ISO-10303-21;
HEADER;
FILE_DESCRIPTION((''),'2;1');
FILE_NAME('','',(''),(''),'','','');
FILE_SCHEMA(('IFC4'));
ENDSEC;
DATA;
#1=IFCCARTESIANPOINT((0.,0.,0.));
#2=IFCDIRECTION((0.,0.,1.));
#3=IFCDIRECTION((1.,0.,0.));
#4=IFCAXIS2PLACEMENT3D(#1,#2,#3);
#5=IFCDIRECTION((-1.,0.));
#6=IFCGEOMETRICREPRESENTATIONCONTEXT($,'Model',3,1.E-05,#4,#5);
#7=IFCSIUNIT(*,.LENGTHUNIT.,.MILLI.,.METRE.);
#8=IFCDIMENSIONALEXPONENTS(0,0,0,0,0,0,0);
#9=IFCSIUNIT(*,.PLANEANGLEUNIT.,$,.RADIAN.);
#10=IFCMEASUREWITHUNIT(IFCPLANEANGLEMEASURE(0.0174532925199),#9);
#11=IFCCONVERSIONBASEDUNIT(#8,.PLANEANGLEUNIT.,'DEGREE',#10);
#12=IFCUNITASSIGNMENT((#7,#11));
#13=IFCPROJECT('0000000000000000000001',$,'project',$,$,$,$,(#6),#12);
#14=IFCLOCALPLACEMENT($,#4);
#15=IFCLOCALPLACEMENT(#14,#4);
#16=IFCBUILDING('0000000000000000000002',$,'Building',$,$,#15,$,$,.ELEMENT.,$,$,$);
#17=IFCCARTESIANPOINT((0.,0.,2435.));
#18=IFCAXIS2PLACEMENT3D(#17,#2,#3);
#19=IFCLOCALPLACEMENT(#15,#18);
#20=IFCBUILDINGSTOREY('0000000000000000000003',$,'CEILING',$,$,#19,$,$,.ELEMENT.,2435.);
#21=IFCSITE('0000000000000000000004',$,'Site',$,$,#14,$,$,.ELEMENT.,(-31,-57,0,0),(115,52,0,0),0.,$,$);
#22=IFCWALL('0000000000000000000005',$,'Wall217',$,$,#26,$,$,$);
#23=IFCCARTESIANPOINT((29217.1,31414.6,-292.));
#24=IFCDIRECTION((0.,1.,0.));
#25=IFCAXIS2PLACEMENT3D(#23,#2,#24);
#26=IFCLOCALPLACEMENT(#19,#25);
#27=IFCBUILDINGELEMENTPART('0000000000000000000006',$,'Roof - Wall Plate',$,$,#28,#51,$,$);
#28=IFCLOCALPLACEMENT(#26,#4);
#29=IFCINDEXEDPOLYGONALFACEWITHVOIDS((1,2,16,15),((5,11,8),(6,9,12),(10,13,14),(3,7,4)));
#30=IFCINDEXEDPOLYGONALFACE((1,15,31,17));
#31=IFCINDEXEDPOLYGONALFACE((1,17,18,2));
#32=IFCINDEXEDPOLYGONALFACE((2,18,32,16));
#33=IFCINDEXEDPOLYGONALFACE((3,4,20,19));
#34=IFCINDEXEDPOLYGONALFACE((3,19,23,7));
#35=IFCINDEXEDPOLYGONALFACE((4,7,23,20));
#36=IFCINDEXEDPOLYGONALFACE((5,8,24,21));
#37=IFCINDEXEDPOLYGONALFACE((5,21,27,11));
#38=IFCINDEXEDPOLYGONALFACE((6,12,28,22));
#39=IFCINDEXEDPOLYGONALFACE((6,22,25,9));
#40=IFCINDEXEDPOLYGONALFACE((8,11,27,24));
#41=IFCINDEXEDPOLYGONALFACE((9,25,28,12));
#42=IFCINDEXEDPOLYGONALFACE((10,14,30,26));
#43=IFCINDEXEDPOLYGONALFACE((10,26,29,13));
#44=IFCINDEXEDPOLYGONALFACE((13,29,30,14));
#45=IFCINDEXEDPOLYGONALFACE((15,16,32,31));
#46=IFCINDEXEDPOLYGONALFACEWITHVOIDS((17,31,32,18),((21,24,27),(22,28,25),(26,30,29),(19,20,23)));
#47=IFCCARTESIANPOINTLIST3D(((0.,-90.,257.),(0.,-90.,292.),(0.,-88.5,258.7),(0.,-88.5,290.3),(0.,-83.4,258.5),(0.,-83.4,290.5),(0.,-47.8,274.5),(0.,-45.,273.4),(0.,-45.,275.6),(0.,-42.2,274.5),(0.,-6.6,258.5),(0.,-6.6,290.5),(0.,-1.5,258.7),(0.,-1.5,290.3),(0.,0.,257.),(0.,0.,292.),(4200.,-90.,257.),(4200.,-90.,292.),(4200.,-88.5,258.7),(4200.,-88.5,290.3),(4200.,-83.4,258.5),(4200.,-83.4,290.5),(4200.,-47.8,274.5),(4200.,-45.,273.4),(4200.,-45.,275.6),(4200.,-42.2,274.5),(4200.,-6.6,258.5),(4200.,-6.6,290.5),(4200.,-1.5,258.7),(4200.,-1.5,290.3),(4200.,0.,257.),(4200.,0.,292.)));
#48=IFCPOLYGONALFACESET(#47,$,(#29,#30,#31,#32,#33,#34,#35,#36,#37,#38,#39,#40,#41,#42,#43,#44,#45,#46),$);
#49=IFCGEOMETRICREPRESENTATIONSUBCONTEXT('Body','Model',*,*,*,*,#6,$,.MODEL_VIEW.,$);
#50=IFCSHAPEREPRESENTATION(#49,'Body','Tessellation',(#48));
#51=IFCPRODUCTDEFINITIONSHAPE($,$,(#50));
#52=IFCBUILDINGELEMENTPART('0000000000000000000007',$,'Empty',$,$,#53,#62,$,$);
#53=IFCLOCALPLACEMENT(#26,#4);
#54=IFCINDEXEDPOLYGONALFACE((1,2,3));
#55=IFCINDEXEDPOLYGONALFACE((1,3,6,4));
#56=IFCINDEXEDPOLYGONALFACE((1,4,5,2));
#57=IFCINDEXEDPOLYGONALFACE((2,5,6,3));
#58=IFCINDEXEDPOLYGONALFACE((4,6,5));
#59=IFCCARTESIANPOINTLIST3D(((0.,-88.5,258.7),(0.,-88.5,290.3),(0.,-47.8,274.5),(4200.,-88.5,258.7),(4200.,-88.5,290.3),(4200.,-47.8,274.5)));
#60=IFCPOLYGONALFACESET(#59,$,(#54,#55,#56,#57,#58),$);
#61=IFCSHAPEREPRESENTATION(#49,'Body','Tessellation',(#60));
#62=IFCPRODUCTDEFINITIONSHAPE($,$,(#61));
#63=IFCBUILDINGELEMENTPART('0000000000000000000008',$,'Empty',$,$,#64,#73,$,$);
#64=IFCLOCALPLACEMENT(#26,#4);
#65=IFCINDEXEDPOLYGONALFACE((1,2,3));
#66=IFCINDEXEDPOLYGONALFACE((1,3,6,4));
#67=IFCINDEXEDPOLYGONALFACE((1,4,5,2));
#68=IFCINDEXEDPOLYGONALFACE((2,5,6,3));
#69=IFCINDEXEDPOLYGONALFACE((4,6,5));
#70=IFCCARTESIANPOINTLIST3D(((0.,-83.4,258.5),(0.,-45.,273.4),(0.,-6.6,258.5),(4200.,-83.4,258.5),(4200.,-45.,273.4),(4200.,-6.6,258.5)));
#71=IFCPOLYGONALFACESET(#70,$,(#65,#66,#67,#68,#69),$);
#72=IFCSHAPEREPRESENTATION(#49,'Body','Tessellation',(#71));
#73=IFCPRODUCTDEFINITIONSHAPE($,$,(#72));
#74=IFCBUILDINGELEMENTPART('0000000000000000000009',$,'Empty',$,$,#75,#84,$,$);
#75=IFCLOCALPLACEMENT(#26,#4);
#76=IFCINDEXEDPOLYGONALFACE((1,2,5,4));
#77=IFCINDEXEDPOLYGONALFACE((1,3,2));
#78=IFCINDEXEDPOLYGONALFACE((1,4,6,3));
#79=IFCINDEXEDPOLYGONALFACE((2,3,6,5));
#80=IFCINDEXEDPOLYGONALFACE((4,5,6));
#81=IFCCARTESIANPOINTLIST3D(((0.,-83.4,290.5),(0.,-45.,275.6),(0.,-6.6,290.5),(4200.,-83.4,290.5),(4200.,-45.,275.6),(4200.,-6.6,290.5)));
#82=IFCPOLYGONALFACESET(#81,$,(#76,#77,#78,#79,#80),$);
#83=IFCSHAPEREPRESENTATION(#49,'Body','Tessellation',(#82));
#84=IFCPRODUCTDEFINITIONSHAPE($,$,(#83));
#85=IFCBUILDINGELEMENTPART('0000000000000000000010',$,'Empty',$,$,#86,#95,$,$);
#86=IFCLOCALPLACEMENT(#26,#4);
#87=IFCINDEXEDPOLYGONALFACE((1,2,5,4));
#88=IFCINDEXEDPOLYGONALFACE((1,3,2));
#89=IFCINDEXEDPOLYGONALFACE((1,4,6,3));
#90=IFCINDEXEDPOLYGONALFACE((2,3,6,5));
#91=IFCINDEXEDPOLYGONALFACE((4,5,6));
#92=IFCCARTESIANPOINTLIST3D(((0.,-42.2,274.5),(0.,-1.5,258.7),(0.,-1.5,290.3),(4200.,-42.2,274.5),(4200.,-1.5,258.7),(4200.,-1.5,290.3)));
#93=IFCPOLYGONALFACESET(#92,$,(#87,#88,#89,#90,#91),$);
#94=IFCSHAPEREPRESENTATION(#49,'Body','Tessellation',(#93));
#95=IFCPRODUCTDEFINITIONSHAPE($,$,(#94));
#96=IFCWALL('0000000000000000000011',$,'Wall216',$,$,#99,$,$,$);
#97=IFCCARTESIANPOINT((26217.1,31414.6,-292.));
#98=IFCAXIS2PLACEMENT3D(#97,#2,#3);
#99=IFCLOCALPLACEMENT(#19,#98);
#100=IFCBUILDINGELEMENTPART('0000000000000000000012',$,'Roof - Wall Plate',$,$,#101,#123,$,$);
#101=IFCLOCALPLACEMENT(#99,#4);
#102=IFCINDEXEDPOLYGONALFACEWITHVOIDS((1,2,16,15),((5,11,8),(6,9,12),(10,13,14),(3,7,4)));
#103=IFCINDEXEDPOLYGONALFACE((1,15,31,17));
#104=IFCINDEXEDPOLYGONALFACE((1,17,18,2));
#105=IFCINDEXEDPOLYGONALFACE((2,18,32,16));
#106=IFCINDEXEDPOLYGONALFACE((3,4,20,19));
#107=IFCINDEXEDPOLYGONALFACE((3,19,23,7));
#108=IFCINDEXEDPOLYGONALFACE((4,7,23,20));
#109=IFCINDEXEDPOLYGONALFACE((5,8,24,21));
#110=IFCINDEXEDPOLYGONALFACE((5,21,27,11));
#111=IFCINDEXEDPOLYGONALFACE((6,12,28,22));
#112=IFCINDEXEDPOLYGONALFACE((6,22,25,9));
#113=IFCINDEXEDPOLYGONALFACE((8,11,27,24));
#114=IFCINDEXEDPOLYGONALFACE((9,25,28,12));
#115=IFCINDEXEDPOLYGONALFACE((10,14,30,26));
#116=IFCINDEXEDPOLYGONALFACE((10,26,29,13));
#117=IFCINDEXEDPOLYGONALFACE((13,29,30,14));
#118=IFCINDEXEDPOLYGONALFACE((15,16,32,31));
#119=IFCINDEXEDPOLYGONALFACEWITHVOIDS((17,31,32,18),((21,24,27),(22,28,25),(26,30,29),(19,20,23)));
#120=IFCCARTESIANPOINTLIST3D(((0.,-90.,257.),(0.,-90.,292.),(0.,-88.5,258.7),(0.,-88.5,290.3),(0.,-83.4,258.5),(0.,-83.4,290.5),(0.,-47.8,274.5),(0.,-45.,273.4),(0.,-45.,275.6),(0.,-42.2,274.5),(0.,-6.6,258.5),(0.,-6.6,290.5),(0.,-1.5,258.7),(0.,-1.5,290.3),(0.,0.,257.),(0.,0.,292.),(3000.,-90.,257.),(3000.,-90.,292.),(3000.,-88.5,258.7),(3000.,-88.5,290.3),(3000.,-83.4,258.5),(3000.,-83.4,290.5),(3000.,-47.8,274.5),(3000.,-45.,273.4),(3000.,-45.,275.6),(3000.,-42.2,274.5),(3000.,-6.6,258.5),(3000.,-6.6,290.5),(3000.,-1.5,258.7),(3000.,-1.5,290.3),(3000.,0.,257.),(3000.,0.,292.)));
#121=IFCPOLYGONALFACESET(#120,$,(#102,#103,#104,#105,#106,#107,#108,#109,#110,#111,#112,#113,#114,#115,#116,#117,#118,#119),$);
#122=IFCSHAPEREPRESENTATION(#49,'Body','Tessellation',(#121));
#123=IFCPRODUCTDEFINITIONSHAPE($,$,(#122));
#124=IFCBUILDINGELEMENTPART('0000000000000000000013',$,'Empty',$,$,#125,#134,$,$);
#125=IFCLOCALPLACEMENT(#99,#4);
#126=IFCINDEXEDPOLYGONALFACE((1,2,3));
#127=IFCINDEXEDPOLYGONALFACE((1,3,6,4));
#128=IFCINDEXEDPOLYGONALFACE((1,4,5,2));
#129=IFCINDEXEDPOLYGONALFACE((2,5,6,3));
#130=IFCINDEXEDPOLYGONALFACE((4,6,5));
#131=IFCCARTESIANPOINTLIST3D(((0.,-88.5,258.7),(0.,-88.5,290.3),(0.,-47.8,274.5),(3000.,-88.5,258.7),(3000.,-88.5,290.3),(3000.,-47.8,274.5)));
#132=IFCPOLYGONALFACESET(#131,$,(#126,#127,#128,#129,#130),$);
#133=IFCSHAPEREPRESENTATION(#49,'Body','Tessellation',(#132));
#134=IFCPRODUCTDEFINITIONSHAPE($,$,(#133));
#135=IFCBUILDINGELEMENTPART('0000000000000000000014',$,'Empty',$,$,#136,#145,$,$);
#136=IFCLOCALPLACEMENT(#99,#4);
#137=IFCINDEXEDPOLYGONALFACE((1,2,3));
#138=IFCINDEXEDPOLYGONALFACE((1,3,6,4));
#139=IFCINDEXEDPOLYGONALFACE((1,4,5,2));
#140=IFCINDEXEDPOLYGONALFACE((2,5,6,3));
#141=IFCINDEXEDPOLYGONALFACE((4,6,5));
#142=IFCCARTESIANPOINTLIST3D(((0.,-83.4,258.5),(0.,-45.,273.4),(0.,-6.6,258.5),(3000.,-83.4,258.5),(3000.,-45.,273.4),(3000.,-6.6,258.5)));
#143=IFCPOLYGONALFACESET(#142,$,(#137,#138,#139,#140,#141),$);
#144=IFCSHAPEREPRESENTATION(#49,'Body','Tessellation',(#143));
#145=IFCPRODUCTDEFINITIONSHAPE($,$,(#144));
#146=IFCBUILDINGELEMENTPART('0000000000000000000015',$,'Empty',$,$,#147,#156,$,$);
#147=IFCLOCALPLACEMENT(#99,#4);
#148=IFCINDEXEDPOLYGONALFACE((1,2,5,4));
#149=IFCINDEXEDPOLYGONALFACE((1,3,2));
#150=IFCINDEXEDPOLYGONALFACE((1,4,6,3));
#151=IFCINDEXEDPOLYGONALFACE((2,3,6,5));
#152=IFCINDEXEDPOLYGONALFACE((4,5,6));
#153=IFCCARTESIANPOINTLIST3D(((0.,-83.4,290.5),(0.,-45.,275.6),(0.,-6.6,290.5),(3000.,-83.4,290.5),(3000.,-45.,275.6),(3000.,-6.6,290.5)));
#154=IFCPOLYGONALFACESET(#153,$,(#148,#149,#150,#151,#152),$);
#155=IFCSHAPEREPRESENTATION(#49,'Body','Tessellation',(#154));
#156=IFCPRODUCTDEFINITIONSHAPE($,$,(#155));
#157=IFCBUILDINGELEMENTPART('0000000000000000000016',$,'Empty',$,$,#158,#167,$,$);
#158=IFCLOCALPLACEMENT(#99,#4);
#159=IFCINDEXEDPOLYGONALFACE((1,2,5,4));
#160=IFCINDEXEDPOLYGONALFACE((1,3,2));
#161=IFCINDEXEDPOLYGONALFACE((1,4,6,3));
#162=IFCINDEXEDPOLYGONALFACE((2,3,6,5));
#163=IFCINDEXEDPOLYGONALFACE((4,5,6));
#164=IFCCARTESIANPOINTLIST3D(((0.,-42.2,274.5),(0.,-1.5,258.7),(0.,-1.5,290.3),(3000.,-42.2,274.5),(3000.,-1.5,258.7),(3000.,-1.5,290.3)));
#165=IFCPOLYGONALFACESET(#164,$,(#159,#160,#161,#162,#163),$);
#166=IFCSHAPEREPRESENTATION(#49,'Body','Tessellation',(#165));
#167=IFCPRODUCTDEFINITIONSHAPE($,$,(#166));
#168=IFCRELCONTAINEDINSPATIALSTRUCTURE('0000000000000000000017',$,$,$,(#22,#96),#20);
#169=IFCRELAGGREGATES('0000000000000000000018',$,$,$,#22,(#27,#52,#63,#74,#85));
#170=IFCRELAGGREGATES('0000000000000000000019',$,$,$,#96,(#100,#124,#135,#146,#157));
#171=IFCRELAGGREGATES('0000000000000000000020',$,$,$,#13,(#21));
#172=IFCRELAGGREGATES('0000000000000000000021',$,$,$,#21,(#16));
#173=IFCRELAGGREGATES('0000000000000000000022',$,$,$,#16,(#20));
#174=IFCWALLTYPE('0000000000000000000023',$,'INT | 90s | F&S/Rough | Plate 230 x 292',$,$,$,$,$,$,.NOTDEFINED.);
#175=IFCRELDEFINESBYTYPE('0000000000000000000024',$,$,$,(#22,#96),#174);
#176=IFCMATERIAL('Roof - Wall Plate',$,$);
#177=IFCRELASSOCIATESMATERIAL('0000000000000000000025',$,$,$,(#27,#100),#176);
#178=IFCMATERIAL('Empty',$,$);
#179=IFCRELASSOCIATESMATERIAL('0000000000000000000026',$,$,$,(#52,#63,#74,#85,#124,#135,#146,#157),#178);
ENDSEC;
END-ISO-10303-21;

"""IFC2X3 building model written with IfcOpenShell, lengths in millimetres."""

from ifc_helpers import new_model, entity, si_unit, converted_unit, direction, frame, origin_with_axes, place, context, subcontext, project, spatial, polyline, outline, extrude, material, type_object, element, aggregate, save


model = new_model("IFC2X3")

# Units and contexts
model_context = context("Model", 3, precision=1e-05, world=origin_with_axes(), true_north=direction((-1.0, 0.0)))
body_context = subcontext(model_context, "Body", "Model", "MODEL_VIEW")
ifc_project = project(units=[si_unit("LENGTHUNIT", "METRE", prefix="MILLI"), converted_unit("PLANEANGLEUNIT", "DEGREE", entity("IfcPlaneAngleMeasure", 0.0174532925199), si_unit("PLANEANGLEUNIT", "RADIAN"), dimensions=[0, 0, 0, 0, 0, 0, 0])], contexts=[model_context])

# Site, building, storey
site_placement = place(None, origin_with_axes())
site = spatial("IfcSite", under=ifc_project, at=site_placement, Name="Site", CompositionType="ELEMENT", RefLatitude=(-31, -57, 0, 0), RefLongitude=(115, 52, 0, 0), RefElevation=0.0)
building_placement = place(site_placement, origin_with_axes())
building = spatial("IfcBuilding", under=site, at=building_placement, Name="Building", CompositionType="ELEMENT")
storey_placement = place(building_placement, frame((0.0, 0.0, 2435.0), z_axis=(0.0, 0.0, 1.0), x_axis=(1.0, 0.0, 0.0)))
storey = spatial("IfcBuildingStorey", under=building, at=storey_placement, Name="CEILING", CompositionType="ELEMENT", Elevation=2435.0)

# Walls, building element parts
wall_type = type_object("IfcWallType", Name="INT | 90s | F&S/Rough | Plate 230 x 292", PredefinedType="NOTDEFINED")
wall_1_placement = place(storey_placement, frame((29217.1, 31414.6, -292.0), z_axis=(0.0, 0.0, 1.0), x_axis=(0.0, 1.0, 0.0)))
wall_1 = element("IfcWall", 1, at=wall_1_placement, inside=storey, type_object=wall_type, Name="Wall217")
ifc_material_1 = material(Name="Roof - Wall Plate")
building_element_part_1_placement = place(wall_1_placement, origin_with_axes())
building_element_part_1 = element("IfcBuildingElementPart", 2, at=building_element_part_1_placement, material=ifc_material_1, Name="Roof - Wall Plate", context=body_context, shape_type="SweptSolid", body=[
    extrude(outline(polyline([(-90.0, 257.0), (0.0, 257.0), (0.0, 292.0), (-90.0, 292.0), (-90.0, 257.0)]), holes=[polyline([(-83.4, 290.5), (-6.6, 290.5), (-45.0, 275.6), (-83.4, 290.5)]), polyline([(-42.2, 274.5), (-1.5, 290.3), (-1.5, 258.7), (-42.2, 274.5)]), polyline([(-6.6, 258.5), (-83.4, 258.5), (-45.0, 273.4), (-6.6, 258.5)]), polyline([(-88.5, 258.7), (-88.5, 290.3), (-47.8, 274.5), (-88.5, 258.7)])]), frame((0.0, 0.0, 0.0), z_axis=(1.0, 0.0, 0.0), x_axis=(0.0, 1.0, 0.0)), (0.0, 0.0, 1.0), 4200.0),
])
ifc_material_2 = material(Name="Empty")
building_element_part_2_placement = place(wall_1_placement, origin_with_axes())
building_element_part_2 = element("IfcBuildingElementPart", 3, at=building_element_part_2_placement, material=ifc_material_2, Name="Empty", context=body_context, shape_type="SweptSolid", body=[
    extrude(outline(polyline([(-47.8, 274.5), (-88.5, 290.3), (-88.5, 258.7), (-47.8, 274.5)])), frame((0.0, 0.0, 0.0), z_axis=(1.0, 0.0, 0.0), x_axis=(0.0, 1.0, 0.0)), (0.0, 0.0, 1.0), 4200.0),
])
building_element_part_3_placement = place(wall_1_placement, origin_with_axes())
building_element_part_3 = element("IfcBuildingElementPart", 4, at=building_element_part_3_placement, material=ifc_material_2, Name="Empty", context=body_context, shape_type="SweptSolid", body=[
    extrude(outline(polyline([(-6.6, 258.5), (-45.0, 273.4), (-83.4, 258.5), (-6.6, 258.5)])), frame((0.0, 0.0, 0.0), z_axis=(1.0, 0.0, 0.0), x_axis=(0.0, 1.0, 0.0)), (0.0, 0.0, 1.0), 4200.0),
])
building_element_part_4_placement = place(wall_1_placement, origin_with_axes())
building_element_part_4 = element("IfcBuildingElementPart", 5, at=building_element_part_4_placement, material=ifc_material_2, Name="Empty", context=body_context, shape_type="SweptSolid", body=[
    extrude(outline(polyline([(-45.0, 275.6), (-6.6, 290.5), (-83.4, 290.5), (-45.0, 275.6)])), frame((0.0, 0.0, 0.0), z_axis=(1.0, 0.0, 0.0), x_axis=(0.0, 1.0, 0.0)), (0.0, 0.0, 1.0), 4200.0),
])
building_element_part_5_placement = place(wall_1_placement, origin_with_axes())
building_element_part_5 = element("IfcBuildingElementPart", 6, at=building_element_part_5_placement, material=ifc_material_2, Name="Empty", context=body_context, shape_type="SweptSolid", body=[
    extrude(outline(polyline([(-42.2, 274.5), (-1.5, 258.7), (-1.5, 290.3), (-42.2, 274.5)])), frame((0.0, 0.0, 0.0), z_axis=(1.0, 0.0, 0.0), x_axis=(0.0, 1.0, 0.0)), (0.0, 0.0, 1.0), 4200.0),
])
aggregate(wall_1, [building_element_part_1, building_element_part_2, building_element_part_3, building_element_part_4, building_element_part_5])
wall_2_placement = place(storey_placement, frame((26217.1, 31414.6, -292.0), z_axis=(0.0, 0.0, 1.0), x_axis=(1.0, 0.0, 0.0)))
wall_2 = element("IfcWall", 7, at=wall_2_placement, inside=storey, type_object=wall_type, Name="Wall216")
building_element_part_6_placement = place(wall_2_placement, origin_with_axes())
building_element_part_6 = element("IfcBuildingElementPart", 8, at=building_element_part_6_placement, material=ifc_material_1, Name="Roof - Wall Plate", context=body_context, shape_type="SweptSolid", body=[
    extrude(outline(polyline([(-90.0, 257.0), (0.0, 257.0), (0.0, 292.0), (-90.0, 292.0), (-90.0, 257.0)]), holes=[polyline([(-83.4, 290.5), (-6.6, 290.5), (-45.0, 275.6), (-83.4, 290.5)]), polyline([(-42.2, 274.5), (-1.5, 290.3), (-1.5, 258.7), (-42.2, 274.5)]), polyline([(-6.6, 258.5), (-83.4, 258.5), (-45.0, 273.4), (-6.6, 258.5)]), polyline([(-88.5, 258.7), (-88.5, 290.3), (-47.8, 274.5), (-88.5, 258.7)])]), frame((0.0, 0.0, 0.0), z_axis=(1.0, 0.0, 0.0), x_axis=(0.0, 1.0, 0.0)), (0.0, 0.0, 1.0), 3000.0),
])
building_element_part_7_placement = place(wall_2_placement, origin_with_axes())
building_element_part_7 = element("IfcBuildingElementPart", 9, at=building_element_part_7_placement, material=ifc_material_2, Name="Empty", context=body_context, shape_type="SweptSolid", body=[
    extrude(outline(polyline([(-47.8, 274.5), (-88.5, 290.3), (-88.5, 258.7), (-47.8, 274.5)])), frame((0.0, 0.0, 0.0), z_axis=(1.0, 0.0, 0.0), x_axis=(0.0, 1.0, 0.0)), (0.0, 0.0, 1.0), 3000.0),
])
building_element_part_8_placement = place(wall_2_placement, origin_with_axes())
building_element_part_8 = element("IfcBuildingElementPart", 10, at=building_element_part_8_placement, material=ifc_material_2, Name="Empty", context=body_context, shape_type="SweptSolid", body=[
    extrude(outline(polyline([(-6.6, 258.5), (-45.0, 273.4), (-83.4, 258.5), (-6.6, 258.5)])), frame((0.0, 0.0, 0.0), z_axis=(1.0, 0.0, 0.0), x_axis=(0.0, 1.0, 0.0)), (0.0, 0.0, 1.0), 3000.0),
])
building_element_part_9_placement = place(wall_2_placement, origin_with_axes())
building_element_part_9 = element("IfcBuildingElementPart", 11, at=building_element_part_9_placement, material=ifc_material_2, Name="Empty", context=body_context, shape_type="SweptSolid", body=[
    extrude(outline(polyline([(-45.0, 275.6), (-6.6, 290.5), (-83.4, 290.5), (-45.0, 275.6)])), frame((0.0, 0.0, 0.0), z_axis=(1.0, 0.0, 0.0), x_axis=(0.0, 1.0, 0.0)), (0.0, 0.0, 1.0), 3000.0),
])
building_element_part_10_placement = place(wall_2_placement, origin_with_axes())
building_element_part_10 = element("IfcBuildingElementPart", 12, at=building_element_part_10_placement, material=ifc_material_2, Name="Empty", context=body_context, shape_type="SweptSolid", body=[
    extrude(outline(polyline([(-42.2, 274.5), (-1.5, 258.7), (-1.5, 290.3), (-42.2, 274.5)])), frame((0.0, 0.0, 0.0), z_axis=(1.0, 0.0, 0.0), x_axis=(0.0, 1.0, 0.0)), (0.0, 0.0, 1.0), 3000.0),
])
aggregate(wall_2, [building_element_part_6, building_element_part_7, building_element_part_8, building_element_part_9, building_element_part_10])

save(model, "model.ifc")
